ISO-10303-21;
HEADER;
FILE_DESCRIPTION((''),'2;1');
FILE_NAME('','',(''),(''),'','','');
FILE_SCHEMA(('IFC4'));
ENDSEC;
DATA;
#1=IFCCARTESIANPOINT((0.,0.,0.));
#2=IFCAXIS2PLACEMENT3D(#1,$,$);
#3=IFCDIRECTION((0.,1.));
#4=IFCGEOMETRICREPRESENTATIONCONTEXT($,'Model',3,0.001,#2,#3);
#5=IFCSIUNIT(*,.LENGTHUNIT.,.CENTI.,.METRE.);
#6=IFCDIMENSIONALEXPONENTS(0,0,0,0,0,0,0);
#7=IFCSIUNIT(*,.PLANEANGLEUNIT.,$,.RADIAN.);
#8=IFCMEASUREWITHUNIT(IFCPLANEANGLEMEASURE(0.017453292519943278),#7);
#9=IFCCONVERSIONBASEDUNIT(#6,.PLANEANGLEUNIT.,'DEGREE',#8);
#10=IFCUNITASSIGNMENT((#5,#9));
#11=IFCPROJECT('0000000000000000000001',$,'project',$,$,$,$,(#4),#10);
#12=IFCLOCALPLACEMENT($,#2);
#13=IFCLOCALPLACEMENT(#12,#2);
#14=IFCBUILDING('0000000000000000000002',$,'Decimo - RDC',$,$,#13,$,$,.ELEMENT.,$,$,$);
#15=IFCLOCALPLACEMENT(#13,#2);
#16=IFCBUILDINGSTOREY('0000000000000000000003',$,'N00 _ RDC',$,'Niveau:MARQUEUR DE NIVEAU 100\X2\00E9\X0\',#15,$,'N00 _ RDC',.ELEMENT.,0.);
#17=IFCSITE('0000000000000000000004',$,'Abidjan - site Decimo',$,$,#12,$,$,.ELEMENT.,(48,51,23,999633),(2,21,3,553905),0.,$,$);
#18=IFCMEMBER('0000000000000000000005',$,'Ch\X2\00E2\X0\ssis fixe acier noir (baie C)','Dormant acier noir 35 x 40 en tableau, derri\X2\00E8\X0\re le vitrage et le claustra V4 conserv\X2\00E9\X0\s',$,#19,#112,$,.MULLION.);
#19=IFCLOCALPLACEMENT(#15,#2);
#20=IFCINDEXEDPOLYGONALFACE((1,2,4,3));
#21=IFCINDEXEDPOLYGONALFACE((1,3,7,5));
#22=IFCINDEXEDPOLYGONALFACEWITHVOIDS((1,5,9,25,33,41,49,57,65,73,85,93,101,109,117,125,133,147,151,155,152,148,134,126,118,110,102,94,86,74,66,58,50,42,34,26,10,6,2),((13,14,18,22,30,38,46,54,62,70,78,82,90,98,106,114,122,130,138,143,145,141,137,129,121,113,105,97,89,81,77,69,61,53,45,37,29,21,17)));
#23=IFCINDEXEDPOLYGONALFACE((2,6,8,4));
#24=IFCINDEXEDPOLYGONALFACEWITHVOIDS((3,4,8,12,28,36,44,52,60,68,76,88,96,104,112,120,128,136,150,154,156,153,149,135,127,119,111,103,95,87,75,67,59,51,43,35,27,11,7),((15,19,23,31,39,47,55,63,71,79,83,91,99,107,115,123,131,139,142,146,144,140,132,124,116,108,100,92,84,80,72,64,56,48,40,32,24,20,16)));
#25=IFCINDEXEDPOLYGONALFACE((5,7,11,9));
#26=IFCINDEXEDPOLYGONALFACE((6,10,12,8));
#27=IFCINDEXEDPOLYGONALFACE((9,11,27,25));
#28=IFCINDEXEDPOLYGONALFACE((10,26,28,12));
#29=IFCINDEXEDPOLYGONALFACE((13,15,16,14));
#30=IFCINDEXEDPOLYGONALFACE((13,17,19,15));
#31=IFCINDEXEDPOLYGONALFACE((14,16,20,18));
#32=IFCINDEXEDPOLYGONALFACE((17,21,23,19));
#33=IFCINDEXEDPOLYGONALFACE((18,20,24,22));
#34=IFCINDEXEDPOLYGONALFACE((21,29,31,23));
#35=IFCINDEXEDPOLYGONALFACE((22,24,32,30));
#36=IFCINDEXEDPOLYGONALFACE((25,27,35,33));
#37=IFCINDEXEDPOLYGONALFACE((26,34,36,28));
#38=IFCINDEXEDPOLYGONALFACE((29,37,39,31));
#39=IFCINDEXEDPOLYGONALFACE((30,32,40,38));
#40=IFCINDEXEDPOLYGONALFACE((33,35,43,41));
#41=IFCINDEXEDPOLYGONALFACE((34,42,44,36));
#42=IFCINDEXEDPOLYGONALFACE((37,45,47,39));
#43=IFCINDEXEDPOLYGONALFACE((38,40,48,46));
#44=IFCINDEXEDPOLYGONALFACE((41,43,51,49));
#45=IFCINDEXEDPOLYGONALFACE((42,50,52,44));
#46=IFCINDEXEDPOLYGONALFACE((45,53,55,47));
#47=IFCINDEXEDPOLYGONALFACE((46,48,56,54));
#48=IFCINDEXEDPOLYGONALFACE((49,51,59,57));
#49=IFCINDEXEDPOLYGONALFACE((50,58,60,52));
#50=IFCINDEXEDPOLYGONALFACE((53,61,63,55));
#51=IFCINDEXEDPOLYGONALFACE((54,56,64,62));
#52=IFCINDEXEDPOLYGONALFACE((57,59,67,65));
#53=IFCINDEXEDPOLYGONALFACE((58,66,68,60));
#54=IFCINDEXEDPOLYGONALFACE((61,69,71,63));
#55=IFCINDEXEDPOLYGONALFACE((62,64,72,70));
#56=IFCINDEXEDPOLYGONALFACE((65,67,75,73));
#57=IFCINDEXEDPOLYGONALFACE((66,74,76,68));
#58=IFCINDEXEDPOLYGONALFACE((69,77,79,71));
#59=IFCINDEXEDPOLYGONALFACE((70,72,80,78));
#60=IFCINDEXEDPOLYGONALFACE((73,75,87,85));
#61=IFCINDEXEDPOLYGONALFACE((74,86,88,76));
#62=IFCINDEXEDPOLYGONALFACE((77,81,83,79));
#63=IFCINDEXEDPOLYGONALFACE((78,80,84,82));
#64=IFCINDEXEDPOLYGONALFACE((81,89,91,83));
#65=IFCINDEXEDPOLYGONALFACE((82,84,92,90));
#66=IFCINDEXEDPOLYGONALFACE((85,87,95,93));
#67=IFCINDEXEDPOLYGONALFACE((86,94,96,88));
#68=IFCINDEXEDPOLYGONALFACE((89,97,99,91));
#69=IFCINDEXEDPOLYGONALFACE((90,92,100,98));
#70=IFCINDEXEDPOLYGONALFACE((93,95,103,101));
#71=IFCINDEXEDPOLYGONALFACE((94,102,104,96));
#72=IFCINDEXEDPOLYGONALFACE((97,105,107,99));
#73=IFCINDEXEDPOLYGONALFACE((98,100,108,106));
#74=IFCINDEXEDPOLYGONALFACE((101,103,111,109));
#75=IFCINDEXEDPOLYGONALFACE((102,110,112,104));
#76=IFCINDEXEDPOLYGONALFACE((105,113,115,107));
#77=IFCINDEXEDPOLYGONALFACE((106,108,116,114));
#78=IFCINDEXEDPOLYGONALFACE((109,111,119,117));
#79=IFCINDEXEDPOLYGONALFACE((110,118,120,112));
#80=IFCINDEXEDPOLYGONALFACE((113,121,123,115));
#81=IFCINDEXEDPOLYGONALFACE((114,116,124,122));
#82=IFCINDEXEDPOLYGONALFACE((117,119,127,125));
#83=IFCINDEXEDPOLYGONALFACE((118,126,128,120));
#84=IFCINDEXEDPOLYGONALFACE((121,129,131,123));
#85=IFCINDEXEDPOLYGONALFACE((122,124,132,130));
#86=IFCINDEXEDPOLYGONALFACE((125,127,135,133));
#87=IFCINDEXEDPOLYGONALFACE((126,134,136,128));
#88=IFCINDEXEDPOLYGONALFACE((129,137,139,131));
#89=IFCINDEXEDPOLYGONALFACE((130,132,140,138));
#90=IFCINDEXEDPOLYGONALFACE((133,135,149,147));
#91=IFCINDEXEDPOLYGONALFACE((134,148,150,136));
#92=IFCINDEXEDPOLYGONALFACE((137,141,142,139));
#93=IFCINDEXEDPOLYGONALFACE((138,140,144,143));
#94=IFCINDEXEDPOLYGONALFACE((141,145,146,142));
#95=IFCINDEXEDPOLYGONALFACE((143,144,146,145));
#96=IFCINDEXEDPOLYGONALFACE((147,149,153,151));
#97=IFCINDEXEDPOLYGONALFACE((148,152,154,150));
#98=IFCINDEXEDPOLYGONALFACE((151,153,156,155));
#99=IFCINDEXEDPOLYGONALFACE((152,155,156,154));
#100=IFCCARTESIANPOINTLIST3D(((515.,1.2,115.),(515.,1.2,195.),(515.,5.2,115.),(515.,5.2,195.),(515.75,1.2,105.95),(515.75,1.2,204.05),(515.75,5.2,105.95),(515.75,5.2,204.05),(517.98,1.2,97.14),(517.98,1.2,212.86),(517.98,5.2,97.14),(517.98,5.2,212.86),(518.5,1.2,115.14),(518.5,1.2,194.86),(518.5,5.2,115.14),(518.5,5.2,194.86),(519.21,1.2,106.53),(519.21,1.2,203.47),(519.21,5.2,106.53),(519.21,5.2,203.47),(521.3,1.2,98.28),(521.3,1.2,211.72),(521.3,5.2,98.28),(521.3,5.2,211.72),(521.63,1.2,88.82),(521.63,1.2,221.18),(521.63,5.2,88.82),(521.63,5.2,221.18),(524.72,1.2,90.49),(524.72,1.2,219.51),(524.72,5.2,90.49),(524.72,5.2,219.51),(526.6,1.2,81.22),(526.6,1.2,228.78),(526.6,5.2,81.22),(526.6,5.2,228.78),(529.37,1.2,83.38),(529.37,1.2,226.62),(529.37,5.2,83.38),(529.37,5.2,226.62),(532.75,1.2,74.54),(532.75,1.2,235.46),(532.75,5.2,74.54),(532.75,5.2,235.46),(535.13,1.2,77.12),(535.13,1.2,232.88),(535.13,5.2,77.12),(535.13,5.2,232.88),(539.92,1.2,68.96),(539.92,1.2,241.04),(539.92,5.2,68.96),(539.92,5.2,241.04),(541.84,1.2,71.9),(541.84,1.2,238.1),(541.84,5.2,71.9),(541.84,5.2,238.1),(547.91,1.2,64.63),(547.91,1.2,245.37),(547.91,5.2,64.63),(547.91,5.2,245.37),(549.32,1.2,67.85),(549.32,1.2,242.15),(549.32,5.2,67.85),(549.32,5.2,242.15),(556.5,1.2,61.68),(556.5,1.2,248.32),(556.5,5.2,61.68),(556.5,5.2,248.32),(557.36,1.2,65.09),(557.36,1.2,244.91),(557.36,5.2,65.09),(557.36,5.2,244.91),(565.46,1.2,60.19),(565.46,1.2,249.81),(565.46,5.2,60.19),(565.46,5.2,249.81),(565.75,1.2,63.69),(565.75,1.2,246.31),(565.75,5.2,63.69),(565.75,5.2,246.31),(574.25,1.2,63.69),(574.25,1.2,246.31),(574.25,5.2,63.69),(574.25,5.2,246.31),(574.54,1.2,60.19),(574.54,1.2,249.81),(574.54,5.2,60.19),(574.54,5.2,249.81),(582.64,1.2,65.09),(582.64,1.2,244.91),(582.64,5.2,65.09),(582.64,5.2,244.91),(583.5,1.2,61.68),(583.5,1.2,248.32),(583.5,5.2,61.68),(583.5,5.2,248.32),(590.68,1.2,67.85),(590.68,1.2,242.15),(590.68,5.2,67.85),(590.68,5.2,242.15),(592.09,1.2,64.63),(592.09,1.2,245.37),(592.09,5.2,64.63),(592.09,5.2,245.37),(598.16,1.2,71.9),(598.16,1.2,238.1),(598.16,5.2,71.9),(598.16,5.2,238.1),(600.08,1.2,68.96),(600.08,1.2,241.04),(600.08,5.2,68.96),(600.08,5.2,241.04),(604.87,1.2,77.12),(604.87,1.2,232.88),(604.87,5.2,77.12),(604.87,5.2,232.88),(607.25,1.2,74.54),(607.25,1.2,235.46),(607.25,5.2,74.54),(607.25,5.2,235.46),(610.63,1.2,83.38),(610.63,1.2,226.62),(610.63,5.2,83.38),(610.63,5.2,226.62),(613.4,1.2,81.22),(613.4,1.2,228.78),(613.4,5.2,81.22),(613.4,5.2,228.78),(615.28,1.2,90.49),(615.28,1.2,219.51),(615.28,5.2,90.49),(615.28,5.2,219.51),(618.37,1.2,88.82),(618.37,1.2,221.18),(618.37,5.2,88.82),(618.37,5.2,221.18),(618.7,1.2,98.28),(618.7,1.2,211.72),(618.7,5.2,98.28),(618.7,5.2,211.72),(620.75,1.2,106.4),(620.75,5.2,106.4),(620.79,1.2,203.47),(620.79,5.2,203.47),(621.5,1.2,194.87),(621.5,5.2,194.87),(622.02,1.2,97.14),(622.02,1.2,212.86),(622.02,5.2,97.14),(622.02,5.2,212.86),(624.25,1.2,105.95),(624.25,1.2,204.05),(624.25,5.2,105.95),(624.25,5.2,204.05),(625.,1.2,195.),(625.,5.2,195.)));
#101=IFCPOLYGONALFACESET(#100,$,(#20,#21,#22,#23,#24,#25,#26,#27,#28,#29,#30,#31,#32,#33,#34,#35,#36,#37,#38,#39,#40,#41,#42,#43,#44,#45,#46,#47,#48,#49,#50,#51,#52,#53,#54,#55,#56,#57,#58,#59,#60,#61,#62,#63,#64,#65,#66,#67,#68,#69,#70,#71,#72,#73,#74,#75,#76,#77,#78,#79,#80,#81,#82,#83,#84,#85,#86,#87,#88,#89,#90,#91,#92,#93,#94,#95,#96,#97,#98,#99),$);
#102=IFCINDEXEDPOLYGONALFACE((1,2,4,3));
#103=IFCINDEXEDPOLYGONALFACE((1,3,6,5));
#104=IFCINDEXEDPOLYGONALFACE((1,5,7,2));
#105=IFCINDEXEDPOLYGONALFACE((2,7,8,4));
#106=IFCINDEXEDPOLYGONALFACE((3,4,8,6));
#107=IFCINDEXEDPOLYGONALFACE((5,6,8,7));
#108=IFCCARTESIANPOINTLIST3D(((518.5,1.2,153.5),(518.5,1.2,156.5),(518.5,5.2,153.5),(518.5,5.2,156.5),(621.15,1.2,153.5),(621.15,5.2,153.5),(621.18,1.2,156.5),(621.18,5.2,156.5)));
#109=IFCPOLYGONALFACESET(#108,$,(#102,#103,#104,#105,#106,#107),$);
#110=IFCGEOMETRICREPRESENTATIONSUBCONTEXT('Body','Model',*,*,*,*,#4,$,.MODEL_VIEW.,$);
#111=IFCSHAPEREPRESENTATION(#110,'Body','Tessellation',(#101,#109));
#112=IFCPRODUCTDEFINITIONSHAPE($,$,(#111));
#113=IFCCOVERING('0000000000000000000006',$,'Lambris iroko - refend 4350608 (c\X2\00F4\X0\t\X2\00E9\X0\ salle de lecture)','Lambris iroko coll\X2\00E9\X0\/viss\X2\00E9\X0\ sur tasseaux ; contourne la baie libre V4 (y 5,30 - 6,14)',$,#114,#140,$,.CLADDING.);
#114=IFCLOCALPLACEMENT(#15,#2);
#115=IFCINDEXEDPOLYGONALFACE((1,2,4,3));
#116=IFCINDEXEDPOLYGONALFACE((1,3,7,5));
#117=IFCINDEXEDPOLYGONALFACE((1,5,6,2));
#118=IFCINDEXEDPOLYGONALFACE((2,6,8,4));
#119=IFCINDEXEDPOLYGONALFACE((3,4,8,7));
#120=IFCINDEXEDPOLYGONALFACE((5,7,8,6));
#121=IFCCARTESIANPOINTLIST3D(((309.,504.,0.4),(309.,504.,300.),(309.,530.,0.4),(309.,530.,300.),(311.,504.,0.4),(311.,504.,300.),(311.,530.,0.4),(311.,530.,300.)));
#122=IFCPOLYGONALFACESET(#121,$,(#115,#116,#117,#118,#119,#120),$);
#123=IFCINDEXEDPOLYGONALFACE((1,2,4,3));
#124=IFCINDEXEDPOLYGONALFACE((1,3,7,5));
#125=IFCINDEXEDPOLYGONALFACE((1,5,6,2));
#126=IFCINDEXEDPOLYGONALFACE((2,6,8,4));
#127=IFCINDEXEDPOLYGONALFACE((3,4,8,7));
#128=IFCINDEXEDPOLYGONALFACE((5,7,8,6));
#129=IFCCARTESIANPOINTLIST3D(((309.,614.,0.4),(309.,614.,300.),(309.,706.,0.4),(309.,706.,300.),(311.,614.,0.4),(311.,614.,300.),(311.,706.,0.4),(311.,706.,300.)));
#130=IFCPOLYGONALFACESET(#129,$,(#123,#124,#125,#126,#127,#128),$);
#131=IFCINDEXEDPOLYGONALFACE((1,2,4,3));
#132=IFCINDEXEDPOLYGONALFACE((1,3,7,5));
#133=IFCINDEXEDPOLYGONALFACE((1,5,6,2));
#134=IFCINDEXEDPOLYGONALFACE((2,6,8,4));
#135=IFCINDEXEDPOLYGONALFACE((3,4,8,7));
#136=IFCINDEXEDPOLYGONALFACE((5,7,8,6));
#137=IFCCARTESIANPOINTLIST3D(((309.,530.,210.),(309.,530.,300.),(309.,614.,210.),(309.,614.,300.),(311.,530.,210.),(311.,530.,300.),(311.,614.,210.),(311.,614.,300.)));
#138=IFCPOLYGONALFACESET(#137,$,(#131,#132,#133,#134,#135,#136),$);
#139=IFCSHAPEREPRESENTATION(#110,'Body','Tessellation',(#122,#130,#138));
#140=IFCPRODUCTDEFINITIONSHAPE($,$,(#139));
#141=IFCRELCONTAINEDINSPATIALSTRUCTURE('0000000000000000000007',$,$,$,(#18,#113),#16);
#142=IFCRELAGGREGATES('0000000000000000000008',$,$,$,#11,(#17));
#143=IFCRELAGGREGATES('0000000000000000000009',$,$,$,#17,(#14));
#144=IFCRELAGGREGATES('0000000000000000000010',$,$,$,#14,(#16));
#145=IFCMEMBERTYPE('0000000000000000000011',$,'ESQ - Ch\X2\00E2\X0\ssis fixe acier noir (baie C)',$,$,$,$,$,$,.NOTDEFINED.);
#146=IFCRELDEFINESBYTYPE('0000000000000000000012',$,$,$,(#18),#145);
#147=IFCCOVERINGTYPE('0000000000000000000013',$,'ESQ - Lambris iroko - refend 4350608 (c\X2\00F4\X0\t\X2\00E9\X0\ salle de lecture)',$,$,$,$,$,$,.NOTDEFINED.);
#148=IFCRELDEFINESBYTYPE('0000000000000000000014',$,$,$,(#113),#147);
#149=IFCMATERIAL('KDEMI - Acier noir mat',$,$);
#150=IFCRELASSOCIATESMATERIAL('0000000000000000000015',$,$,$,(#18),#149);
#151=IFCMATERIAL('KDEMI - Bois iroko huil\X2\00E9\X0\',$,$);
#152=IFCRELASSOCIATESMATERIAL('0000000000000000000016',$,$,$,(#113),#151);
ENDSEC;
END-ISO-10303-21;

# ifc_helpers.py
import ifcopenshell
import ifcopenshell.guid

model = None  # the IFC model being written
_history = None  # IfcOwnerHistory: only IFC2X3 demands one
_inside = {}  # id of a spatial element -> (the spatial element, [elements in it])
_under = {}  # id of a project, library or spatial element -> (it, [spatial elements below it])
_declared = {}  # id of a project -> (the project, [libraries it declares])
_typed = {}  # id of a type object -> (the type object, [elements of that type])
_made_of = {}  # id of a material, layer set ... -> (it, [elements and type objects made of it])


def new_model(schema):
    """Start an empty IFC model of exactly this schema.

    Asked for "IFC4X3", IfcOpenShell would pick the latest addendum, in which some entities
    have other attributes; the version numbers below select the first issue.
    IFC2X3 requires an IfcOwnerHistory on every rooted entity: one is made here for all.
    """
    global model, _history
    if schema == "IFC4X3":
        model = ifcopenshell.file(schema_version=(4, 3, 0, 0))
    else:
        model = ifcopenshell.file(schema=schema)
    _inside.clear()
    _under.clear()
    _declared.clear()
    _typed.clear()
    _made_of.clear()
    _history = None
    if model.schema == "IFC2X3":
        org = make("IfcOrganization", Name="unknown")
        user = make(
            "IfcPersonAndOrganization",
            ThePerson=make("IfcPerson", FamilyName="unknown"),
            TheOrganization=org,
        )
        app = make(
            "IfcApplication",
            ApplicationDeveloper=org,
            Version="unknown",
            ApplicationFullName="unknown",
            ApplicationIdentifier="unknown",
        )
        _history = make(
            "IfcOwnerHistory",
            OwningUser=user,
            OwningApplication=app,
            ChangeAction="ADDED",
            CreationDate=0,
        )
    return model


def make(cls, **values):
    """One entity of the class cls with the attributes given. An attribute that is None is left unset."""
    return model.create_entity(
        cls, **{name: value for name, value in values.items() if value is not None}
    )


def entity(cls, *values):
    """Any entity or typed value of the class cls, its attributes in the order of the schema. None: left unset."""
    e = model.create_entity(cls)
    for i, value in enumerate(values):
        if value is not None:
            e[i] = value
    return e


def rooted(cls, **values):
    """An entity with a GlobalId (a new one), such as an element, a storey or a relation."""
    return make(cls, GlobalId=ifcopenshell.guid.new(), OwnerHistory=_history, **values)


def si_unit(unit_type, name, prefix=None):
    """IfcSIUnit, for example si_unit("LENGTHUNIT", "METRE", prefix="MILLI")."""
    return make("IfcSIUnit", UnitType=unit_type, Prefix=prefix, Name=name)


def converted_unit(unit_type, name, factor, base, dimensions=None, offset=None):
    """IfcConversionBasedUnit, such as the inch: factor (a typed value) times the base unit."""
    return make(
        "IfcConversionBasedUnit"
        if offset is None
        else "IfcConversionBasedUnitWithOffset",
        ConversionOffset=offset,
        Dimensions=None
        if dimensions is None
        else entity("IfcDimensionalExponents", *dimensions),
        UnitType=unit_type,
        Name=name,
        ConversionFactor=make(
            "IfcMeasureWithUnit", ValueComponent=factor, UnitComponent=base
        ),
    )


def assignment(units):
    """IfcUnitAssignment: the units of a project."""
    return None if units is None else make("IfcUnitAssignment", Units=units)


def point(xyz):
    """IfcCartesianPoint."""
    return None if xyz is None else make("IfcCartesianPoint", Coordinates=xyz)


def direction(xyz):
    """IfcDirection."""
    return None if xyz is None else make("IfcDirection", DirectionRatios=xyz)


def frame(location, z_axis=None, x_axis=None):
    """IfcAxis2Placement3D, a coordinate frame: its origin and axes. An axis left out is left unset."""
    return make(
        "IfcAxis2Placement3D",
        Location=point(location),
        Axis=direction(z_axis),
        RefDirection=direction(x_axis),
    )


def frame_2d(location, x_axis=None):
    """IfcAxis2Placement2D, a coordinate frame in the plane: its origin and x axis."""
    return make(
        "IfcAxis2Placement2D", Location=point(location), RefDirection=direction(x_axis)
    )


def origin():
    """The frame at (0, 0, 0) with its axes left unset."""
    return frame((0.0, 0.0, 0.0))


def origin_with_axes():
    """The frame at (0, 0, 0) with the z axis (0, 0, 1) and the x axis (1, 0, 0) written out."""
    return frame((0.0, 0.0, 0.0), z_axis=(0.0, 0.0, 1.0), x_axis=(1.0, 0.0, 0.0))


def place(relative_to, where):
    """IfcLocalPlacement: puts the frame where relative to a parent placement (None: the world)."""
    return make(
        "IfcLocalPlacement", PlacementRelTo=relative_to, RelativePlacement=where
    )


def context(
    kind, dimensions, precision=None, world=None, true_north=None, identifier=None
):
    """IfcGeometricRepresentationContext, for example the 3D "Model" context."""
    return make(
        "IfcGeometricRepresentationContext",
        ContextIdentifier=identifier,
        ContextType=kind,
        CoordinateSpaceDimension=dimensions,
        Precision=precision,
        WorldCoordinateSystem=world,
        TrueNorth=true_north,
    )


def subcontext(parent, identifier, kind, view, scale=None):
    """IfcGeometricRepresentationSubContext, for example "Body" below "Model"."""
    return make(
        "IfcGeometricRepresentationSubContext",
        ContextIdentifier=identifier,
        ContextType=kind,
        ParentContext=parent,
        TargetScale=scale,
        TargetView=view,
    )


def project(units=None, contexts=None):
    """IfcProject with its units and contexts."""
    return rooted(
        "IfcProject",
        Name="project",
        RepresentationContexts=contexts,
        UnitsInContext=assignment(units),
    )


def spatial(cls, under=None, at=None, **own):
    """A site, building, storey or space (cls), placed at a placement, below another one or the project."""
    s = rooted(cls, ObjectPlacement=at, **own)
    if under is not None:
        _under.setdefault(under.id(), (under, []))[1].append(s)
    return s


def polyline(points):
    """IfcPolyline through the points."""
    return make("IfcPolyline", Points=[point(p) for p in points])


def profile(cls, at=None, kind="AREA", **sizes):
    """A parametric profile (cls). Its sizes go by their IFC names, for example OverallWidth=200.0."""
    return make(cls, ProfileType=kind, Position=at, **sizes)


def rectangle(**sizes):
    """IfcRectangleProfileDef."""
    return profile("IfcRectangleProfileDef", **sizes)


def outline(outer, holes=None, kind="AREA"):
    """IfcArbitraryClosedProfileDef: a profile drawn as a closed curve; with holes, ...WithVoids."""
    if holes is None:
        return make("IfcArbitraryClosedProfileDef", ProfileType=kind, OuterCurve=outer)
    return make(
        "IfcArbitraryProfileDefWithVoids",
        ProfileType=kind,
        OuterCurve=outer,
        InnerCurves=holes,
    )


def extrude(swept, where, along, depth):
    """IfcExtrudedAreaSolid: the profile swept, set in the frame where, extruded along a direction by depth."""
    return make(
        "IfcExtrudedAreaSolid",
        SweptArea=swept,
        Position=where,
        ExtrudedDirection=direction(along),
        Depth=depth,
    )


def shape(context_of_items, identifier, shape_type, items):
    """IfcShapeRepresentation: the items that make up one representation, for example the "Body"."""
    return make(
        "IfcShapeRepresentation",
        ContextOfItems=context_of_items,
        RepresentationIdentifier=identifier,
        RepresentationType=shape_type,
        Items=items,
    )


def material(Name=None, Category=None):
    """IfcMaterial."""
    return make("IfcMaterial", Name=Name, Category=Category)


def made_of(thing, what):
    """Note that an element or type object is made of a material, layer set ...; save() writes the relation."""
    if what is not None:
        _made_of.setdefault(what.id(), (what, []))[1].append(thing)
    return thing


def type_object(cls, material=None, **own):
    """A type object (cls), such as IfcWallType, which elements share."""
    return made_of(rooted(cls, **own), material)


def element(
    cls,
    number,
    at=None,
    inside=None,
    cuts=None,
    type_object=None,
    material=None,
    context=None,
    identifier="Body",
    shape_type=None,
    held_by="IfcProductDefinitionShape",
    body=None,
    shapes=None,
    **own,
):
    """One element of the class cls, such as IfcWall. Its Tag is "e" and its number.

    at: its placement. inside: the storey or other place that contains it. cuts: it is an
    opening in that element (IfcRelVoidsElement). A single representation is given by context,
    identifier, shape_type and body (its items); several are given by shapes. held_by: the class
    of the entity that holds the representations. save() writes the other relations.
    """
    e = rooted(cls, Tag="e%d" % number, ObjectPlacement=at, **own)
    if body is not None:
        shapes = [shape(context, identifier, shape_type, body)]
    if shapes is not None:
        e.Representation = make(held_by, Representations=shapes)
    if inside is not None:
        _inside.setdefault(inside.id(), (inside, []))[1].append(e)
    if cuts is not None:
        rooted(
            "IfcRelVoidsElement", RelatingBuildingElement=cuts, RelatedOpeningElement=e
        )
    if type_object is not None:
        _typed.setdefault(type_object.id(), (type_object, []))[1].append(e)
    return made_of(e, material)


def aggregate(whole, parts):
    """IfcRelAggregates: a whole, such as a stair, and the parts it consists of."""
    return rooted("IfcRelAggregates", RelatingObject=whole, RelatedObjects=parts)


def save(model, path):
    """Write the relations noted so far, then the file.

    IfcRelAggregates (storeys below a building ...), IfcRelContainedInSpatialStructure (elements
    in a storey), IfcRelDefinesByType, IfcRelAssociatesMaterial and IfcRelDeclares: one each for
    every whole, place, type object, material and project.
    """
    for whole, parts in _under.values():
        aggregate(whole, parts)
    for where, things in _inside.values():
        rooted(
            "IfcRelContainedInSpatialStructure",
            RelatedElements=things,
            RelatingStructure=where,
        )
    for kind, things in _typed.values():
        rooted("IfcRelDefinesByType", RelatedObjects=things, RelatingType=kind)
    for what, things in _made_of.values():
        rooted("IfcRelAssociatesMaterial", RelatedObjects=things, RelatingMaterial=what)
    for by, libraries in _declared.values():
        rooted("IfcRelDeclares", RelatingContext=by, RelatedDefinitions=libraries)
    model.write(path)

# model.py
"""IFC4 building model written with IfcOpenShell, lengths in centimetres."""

from ifc_helpers import new_model, entity, si_unit, converted_unit, direction, frame, frame_2d, origin, origin_with_axes, place, context, subcontext, project, spatial, polyline, rectangle, outline, extrude, material, type_object, element, save


model = new_model("IFC4")

# Units and contexts
model_context = context("Model", 3, precision=0.001, world=origin(), true_north=direction((0.0, 1.0)))
body_context = subcontext(model_context, "Body", "Model", "MODEL_VIEW")
ifc_project = project(units=[si_unit("LENGTHUNIT", "METRE", prefix="CENTI"), converted_unit("PLANEANGLEUNIT", "DEGREE", entity("IfcPlaneAngleMeasure", 0.017453292519943278), si_unit("PLANEANGLEUNIT", "RADIAN"), dimensions=[0, 0, 0, 0, 0, 0, 0])], contexts=[model_context])

# Site, building, storey
site_placement = place(None, origin())
site = spatial("IfcSite", under=ifc_project, at=site_placement, Name="Abidjan - site Decimo", CompositionType="ELEMENT", RefLatitude=(48, 51, 23, 999633), RefLongitude=(2, 21, 3, 553905), RefElevation=0.0)
building_placement = place(site_placement, origin())
building = spatial("IfcBuilding", under=site, at=building_placement, Name="Decimo - RDC", CompositionType="ELEMENT")
storey_placement = place(building_placement, origin())
storey = spatial("IfcBuildingStorey", under=building, at=storey_placement, Name="N00 _ RDC", ObjectType="Niveau:MARQUEUR DE NIVEAU 100é", LongName="N00 _ RDC", CompositionType="ELEMENT", Elevation=0.0)

# Member
ifc_material_1 = material(Name="KDEMI - Acier noir mat")
member_type_1 = type_object("IfcMemberType", Name="ESQ - Châssis fixe acier noir (baie C)", PredefinedType="NOTDEFINED")
member_1_placement = place(storey_placement, origin_with_axes())
element("IfcMember", 1, at=member_1_placement, inside=storey, type_object=member_type_1, material=ifc_material_1, Name="Châssis fixe acier noir (baie C)", Description="Dormant acier noir 35 x 40 en tableau, derrière le vitrage et le claustra V4 conservés", PredefinedType="MULLION", context=body_context, shape_type="SweptSolid", body=[
    extrude(outline(polyline([(624.25, 105.95), (622.02, 97.14), (618.37, 88.82), (613.4, 81.22), (607.25, 74.54), (600.08, 68.96), (592.09, 64.63), (583.5, 61.68), (574.54, 60.19), (565.46, 60.19), (556.5, 61.68), (547.91, 64.63), (539.92, 68.96), (532.75, 74.54), (526.6, 81.22), (521.63, 88.82), (517.98, 97.14), (515.75, 105.95), (515.0, 115.0), (515.0, 195.0), (515.75, 204.05), (517.98, 212.86), (521.63, 221.18), (526.6, 228.78), (532.75, 235.46), (539.92, 241.04), (547.91, 245.37), (556.5, 248.32), (565.46, 249.81), (574.54, 249.81), (583.5, 248.32), (592.09, 245.37), (600.08, 241.04), (607.25, 235.46), (613.4, 228.78), (618.37, 221.18), (622.02, 212.86), (624.25, 204.05), (625.0, 195.0), (624.25, 105.95)]), holes=[polyline([(620.79, 203.47), (618.7, 211.72), (615.28, 219.51), (610.63, 226.62), (604.87, 232.88), (598.16, 238.1), (590.68, 242.15), (582.64, 244.91), (574.25, 246.31), (565.75, 246.31), (557.36, 244.91), (549.32, 242.15), (541.84, 238.1), (535.13, 232.88), (529.37, 226.62), (524.72, 219.51), (521.3, 211.72), (519.21, 203.47), (518.5, 194.86), (518.5, 115.14), (519.21, 106.53), (521.3, 98.28), (524.72, 90.49), (529.37, 83.38), (535.13, 77.12), (541.84, 71.9), (549.32, 67.85), (557.36, 65.09), (565.75, 63.69), (574.25, 63.69), (582.64, 65.09), (590.68, 67.85), (598.16, 71.9), (604.87, 77.12), (610.63, 83.38), (615.28, 90.49), (618.7, 98.28), (620.75, 106.4), (621.5, 194.87), (620.79, 203.47)])]), frame((0.0, 5.2, 0.0), z_axis=(0.0, -1.0, 0.0), x_axis=(1.0, 0.0, 0.0)), (0.0, 0.0, 1.0), 4.0),
    extrude(outline(polyline([(621.18, 156.5), (621.15, 153.5), (518.5, 153.5), (518.5, 156.5), (621.18, 156.5)])), frame((0.0, 5.2, 0.0), z_axis=(0.0, -1.0, 0.0), x_axis=(1.0, 0.0, 0.0)), (0.0, 0.0, 1.0), 4.0),
])

# Covering
ifc_material_2 = material(Name="KDEMI - Bois iroko huilé")
covering_type = type_object("IfcCoveringType", Name="ESQ - Lambris iroko - refend 4350608 (côté salle de lecture)", PredefinedType="NOTDEFINED")
covering_placement = place(storey_placement, origin_with_axes())
element("IfcCovering", 2, at=covering_placement, inside=storey, type_object=covering_type, material=ifc_material_2, Name="Lambris iroko - refend 4350608 (côté salle de lecture)", Description="Lambris iroko collé/vissé sur tasseaux ; contourne la baie libre V4 (y 5,30 - 6,14)", PredefinedType="CLADDING", context=body_context, shape_type="SweptSolid", body=[
    extrude(rectangle(XDim=2.0, YDim=26.0, at=frame_2d((310.0, 517.0))), frame((0.0, 0.0, 0.4)), (0.0, 0.0, 1.0), 299.6),
    extrude(rectangle(XDim=2.0, YDim=92.0, at=frame_2d((310.0, 660.0))), frame((0.0, 0.0, 0.4)), (0.0, 0.0, 1.0), 299.6),
    extrude(rectangle(XDim=2.0, YDim=84.0, at=frame_2d((310.0, 572.0))), frame((0.0, 0.0, 210.0)), (0.0, 0.0, 1.0), 90.0),
])

save(model, "model.ifc")
